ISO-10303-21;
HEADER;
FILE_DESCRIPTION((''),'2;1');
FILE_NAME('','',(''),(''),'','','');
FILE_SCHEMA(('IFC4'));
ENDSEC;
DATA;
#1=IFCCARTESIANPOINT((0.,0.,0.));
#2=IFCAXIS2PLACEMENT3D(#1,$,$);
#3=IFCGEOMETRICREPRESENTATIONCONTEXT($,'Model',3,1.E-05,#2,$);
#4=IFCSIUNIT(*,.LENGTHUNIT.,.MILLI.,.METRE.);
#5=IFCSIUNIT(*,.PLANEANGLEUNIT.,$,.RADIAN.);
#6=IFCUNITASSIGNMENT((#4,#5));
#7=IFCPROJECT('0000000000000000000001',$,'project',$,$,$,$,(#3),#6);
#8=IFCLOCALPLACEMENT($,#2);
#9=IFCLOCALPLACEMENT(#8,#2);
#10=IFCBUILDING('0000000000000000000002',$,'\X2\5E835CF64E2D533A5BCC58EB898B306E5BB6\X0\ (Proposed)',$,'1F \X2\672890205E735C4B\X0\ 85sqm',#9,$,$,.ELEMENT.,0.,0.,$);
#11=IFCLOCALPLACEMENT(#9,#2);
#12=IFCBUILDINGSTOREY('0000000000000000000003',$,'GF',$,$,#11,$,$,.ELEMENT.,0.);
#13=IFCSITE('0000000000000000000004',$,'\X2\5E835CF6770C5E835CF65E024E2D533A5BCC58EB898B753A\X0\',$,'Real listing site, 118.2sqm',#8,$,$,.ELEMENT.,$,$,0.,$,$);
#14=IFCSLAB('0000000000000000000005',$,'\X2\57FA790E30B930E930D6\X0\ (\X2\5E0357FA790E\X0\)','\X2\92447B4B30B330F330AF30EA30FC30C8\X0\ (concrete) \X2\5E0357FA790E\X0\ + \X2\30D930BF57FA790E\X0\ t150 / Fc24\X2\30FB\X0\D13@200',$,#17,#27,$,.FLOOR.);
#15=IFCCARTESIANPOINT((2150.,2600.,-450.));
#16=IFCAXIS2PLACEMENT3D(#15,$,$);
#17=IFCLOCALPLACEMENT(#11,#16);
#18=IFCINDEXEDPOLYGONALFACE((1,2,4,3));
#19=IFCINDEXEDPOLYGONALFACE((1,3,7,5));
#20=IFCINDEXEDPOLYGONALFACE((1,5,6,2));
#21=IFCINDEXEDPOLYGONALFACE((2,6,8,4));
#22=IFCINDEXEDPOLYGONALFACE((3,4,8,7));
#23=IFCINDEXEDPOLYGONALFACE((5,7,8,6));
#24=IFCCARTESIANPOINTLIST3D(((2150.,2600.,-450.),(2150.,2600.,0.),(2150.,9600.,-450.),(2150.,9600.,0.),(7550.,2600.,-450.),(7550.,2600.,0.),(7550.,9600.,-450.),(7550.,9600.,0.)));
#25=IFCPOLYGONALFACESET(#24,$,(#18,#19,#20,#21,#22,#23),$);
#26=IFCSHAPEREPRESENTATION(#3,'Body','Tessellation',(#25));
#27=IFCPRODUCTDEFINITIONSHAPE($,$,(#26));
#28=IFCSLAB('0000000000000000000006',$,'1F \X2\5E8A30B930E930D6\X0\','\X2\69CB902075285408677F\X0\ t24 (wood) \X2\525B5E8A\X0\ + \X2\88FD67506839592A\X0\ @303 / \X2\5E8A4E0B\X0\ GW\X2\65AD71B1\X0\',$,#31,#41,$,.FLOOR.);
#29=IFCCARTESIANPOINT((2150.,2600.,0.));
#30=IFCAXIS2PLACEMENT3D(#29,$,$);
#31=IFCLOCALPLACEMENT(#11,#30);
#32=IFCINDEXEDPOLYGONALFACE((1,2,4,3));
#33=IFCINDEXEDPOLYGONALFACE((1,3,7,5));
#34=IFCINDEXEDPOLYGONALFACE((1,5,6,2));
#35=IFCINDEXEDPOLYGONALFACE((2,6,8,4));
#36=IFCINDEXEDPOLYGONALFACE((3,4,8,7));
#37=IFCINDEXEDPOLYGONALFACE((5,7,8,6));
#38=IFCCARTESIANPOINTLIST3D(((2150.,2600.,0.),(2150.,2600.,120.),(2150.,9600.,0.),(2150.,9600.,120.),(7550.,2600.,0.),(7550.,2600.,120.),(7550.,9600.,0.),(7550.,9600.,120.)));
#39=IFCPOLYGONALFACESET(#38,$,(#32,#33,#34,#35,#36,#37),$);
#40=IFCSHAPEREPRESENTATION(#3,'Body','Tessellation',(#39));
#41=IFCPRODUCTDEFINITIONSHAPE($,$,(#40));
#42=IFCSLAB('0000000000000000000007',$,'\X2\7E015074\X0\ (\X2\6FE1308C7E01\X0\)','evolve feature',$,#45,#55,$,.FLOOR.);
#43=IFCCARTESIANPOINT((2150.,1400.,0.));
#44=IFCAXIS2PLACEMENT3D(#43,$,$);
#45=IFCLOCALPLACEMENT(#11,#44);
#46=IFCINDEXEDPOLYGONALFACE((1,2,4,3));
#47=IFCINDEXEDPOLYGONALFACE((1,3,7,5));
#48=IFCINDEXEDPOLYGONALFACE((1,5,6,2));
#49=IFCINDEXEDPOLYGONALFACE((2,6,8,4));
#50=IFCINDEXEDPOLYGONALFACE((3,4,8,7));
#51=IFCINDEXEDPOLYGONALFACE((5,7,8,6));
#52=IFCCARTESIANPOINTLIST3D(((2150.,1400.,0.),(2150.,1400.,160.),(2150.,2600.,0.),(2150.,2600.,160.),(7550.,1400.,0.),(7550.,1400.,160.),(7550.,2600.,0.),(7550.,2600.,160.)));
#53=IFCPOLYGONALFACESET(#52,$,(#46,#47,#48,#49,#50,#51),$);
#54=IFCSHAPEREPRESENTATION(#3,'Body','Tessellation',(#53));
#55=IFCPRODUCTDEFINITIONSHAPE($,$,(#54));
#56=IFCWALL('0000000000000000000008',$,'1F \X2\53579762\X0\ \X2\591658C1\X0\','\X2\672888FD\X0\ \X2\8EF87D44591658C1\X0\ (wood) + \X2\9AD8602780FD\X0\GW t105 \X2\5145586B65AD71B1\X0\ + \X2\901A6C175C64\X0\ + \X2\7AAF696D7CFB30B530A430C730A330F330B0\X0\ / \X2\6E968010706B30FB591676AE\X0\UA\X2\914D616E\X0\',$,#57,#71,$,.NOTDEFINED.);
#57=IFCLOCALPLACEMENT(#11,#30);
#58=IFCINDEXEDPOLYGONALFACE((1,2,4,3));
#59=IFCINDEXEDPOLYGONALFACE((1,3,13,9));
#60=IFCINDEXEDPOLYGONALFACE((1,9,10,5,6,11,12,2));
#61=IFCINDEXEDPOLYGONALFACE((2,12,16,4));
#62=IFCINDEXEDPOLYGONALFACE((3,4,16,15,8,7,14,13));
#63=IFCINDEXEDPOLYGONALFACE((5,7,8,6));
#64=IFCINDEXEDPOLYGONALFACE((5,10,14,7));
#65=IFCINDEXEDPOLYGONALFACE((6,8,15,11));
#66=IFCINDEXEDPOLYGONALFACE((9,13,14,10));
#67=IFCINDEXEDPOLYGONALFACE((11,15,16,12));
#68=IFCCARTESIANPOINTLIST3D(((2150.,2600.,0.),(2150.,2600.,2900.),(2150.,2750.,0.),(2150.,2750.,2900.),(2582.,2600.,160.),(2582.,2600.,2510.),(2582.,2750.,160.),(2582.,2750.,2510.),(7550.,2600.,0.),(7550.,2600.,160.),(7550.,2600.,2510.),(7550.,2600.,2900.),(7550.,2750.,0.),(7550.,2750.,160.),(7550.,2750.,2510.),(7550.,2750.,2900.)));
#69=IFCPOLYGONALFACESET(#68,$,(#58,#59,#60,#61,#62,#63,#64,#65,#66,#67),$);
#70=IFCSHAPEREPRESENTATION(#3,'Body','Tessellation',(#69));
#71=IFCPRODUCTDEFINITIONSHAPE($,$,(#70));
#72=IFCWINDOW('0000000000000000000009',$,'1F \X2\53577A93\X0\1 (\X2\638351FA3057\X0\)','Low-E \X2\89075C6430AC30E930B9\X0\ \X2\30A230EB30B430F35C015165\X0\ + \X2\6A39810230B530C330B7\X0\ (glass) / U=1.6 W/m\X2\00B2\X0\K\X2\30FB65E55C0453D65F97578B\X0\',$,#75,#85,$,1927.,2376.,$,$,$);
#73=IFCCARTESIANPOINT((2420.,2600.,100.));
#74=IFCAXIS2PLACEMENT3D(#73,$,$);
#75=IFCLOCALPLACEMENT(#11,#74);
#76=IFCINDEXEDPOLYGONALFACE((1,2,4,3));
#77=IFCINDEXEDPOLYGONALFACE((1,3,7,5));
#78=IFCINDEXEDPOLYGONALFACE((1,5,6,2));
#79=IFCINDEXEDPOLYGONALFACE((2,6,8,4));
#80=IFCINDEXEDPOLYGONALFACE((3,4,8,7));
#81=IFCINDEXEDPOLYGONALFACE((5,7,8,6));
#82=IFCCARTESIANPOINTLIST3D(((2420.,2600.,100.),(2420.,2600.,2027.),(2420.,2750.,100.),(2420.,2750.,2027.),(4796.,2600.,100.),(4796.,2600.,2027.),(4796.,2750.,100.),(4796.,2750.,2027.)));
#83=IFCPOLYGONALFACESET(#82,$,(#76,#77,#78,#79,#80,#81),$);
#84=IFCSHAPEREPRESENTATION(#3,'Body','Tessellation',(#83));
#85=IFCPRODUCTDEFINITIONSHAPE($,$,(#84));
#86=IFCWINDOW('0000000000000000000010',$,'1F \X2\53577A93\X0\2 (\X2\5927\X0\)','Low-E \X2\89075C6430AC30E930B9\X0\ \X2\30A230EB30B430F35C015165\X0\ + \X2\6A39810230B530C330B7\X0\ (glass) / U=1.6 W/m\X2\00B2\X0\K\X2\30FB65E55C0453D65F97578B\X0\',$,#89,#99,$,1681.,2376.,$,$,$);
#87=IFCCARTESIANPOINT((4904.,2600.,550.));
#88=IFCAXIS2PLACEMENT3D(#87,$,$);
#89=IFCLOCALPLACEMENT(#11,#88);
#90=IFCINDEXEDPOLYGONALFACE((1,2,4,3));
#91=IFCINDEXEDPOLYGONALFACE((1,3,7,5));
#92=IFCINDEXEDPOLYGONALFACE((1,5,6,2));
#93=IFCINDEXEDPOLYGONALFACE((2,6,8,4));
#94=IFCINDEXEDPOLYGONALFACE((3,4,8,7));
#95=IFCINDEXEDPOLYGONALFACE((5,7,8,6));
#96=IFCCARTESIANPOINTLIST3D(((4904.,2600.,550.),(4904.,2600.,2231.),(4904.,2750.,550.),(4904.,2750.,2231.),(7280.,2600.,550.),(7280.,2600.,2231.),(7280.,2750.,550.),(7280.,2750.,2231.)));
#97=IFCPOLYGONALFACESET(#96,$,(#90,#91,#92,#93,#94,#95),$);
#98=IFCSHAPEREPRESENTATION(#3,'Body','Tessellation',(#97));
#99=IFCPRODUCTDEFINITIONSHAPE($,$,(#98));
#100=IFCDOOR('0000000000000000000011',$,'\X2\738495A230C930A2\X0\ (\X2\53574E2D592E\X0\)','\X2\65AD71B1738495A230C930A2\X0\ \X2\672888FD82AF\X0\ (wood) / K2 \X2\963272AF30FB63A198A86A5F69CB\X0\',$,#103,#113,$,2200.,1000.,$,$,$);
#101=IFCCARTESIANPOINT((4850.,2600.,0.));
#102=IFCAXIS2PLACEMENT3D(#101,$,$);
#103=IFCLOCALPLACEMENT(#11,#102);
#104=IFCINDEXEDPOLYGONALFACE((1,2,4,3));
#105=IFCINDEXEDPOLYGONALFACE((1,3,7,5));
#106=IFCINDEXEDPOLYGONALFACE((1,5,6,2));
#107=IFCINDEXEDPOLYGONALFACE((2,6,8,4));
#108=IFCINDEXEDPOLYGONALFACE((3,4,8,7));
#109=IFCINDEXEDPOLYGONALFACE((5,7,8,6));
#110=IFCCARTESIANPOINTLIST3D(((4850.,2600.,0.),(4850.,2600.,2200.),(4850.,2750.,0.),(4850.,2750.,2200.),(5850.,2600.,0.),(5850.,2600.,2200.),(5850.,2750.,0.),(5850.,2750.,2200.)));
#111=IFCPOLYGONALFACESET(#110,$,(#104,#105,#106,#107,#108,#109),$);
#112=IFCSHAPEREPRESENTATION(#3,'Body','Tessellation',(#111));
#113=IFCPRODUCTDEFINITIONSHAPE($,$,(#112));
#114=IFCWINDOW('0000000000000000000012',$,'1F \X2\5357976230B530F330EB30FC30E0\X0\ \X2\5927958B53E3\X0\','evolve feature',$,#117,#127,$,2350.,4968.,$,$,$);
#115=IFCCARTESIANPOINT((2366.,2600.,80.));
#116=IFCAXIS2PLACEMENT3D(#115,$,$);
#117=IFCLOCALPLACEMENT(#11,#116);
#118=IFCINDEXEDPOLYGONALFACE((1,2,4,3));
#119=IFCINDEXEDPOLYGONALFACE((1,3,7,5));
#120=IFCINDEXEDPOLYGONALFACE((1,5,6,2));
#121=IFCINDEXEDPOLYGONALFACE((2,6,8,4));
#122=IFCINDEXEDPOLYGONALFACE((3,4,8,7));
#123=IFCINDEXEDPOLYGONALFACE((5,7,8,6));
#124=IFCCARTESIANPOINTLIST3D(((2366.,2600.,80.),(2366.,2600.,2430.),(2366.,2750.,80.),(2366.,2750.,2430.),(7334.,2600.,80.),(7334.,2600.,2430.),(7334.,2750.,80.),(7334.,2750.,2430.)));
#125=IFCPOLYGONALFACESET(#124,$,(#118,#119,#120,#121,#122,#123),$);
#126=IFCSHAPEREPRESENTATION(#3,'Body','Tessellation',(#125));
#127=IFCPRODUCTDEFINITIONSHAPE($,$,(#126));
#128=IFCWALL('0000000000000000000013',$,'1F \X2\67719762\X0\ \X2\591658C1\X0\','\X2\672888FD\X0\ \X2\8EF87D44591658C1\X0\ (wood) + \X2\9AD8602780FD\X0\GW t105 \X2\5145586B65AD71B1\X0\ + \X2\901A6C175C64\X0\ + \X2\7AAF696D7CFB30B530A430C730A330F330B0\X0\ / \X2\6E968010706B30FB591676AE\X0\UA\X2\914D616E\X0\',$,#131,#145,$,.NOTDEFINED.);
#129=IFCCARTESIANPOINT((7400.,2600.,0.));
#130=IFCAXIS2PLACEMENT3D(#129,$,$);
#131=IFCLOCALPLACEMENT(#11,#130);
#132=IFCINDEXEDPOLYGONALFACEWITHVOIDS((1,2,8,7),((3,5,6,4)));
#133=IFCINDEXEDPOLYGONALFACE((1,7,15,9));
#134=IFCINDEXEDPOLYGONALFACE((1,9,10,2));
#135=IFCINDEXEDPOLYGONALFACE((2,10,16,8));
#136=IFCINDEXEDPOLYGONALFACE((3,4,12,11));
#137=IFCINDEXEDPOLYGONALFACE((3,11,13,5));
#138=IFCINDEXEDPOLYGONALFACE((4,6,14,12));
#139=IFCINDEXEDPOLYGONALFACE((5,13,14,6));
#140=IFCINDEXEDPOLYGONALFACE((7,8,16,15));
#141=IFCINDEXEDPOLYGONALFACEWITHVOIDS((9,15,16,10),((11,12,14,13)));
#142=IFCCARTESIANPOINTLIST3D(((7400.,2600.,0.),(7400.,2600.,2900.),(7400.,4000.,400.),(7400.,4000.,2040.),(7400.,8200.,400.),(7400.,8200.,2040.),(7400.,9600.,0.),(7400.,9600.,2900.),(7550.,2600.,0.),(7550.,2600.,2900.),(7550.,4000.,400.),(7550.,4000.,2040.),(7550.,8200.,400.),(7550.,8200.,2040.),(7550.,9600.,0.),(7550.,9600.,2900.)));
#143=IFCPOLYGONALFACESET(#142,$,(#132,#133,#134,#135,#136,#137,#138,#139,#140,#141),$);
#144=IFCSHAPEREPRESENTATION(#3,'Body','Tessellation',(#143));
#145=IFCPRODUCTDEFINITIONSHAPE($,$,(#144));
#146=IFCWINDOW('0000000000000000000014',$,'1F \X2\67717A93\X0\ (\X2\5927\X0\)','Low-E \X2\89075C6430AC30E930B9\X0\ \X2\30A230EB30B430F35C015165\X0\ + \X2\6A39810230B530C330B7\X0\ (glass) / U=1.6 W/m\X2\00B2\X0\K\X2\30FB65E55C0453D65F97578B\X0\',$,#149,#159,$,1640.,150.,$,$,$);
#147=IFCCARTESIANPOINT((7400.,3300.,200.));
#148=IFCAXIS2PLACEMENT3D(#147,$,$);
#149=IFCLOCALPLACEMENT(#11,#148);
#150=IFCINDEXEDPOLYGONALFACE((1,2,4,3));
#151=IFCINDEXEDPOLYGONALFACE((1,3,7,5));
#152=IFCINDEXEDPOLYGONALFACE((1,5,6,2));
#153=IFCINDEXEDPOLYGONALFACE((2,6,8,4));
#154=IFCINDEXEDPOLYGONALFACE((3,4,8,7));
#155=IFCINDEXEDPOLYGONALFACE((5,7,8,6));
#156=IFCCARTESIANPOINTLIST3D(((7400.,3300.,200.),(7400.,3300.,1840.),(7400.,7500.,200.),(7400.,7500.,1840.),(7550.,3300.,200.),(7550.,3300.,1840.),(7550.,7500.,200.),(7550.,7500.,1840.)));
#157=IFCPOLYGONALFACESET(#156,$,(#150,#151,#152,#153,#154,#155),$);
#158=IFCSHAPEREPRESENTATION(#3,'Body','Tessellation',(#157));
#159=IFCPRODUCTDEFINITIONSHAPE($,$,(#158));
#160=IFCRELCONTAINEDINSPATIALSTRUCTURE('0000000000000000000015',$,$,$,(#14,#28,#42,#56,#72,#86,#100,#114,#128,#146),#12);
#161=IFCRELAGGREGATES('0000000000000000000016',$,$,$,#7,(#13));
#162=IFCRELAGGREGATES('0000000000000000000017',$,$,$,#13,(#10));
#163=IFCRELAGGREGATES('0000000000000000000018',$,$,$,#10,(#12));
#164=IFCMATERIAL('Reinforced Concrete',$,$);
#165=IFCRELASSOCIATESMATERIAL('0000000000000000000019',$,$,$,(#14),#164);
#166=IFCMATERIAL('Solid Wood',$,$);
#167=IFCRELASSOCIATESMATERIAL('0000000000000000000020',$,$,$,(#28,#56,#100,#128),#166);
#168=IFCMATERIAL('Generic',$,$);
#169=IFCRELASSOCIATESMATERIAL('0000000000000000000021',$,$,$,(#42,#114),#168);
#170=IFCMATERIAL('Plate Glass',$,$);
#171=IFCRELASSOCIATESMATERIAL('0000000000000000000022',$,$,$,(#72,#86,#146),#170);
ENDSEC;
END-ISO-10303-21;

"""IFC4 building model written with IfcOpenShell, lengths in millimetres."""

from ifc_helpers import new_model, si_unit, frame, frame_2d, origin, place, context, project, spatial, rectangle, extrude, material, element, fill, save


model = new_model("IFC4")

# Units and contexts
model_context = context("Model", 3, precision=1e-05, world=origin())
ifc_project = project(units=[si_unit("LENGTHUNIT", "METRE", prefix="MILLI"), si_unit("PLANEANGLEUNIT", "RADIAN")], contexts=[model_context])

# Site, building, storey
site_placement = place(None, origin())
site = spatial("IfcSite", under=ifc_project, at=site_placement, Name="広島県広島市中区富士見町", ObjectType="Real listing site, 118.2sqm", CompositionType="ELEMENT", RefElevation=0.0)
building_placement = place(site_placement, origin())
building = spatial("IfcBuilding", under=site, at=building_placement, Name="広島中区富士見の家 (Proposed)", ObjectType="1F 木造平屋 85sqm", CompositionType="ELEMENT", ElevationOfRefHeight=0.0, ElevationOfTerrain=0.0)
storey_placement = place(building_placement, origin())
storey = spatial("IfcBuildingStorey", under=building, at=storey_placement, Name="GF", CompositionType="ELEMENT", Elevation=0.0)

# Slabs
ifc_material_1 = material(Name="Reinforced Concrete")
slab_1_placement = place(storey_placement, frame((2150.0, 2600.0, -450.0)))
element("IfcSlab", 1, at=slab_1_placement, inside=storey, material=ifc_material_1, Name="基礎スラブ (布基礎)", Description="鉄筋コンクリート (concrete) 布基礎 + ベタ基礎 t150 / Fc24・D13@200", PredefinedType="FLOOR", context=model_context, shape_type="SweptSolid", body=[
    extrude(rectangle(XDim=5400.0, YDim=7000.0, at=frame_2d((2700.0, 3500.0))), frame((2150.0, 2600.0, -450.0)), (0.0, 0.0, 1.0), 450.0),
])
ifc_material_2 = material(Name="Solid Wood")
slab_2_placement = place(storey_placement, frame((2150.0, 2600.0, 0.0)))
element("IfcSlab", 2, at=slab_2_placement, inside=storey, material=ifc_material_2, Name="1F 床スラブ", Description="構造用合板 t24 (wood) 剛床 + 製材根太 @303 / 床下 GW断熱", PredefinedType="FLOOR", context=model_context, shape_type="SweptSolid", body=[
    extrude(rectangle(XDim=5400.0, YDim=7000.0, at=frame_2d((2700.0, 3500.0))), frame((2150.0, 2600.0, 0.0)), (0.0, 0.0, 1.0), 120.0),
])
ifc_material_3 = material(Name="Generic")
slab_3_placement = place(storey_placement, frame((2150.0, 1400.0, 0.0)))
element("IfcSlab", 3, at=slab_3_placement, inside=storey, material=ifc_material_3, Name="縁側 (濡れ縁)", Description="evolve feature", PredefinedType="FLOOR", context=model_context, shape_type="SweptSolid", body=[
    extrude(rectangle(XDim=5400.0, YDim=1200.0, at=frame_2d((2700.0, 600.0))), frame((2150.0, 1400.0, 0.0)), (0.0, 0.0, 1.0), 160.0),
])

# Wall, openings, windows, door
wall_1_placement = place(storey_placement, frame((2150.0, 2600.0, 0.0)))
wall_1 = element("IfcWall", 4, at=wall_1_placement, inside=storey, material=ifc_material_2, Name="1F 南面 外壁", Description="木製 軸組外壁 (wood) + 高性能GW t105 充填断熱 + 通気層 + 窯業系サイディング / 準耐火・外皮UA配慮", PredefinedType="NOTDEFINED", context=model_context, shape_type="SweptSolid", body=[
    extrude(rectangle(XDim=5400.0, YDim=150.0, at=frame_2d((2700.0, 75.0))), frame((2150.0, 2600.0, 0.0)), (0.0, 0.0, 1.0), 2900.0),
])
opening_1_placement = place(storey_placement, frame((2420.0, 2600.0, 100.0)))
opening_1 = element("IfcOpeningElement", 5, at=opening_1_placement, cuts=wall_1, PredefinedType="NOTDEFINED", context=model_context, shape_type="SweptSolid", body=[
    extrude(rectangle(XDim=2376.0, YDim=150.0, at=frame_2d((1188.0, 75.0))), frame((2420.0, 2600.0, 100.0)), (0.0, 0.0, 1.0), 1927.0),
])
opening_2_placement = place(storey_placement, frame((4904.0, 2600.0, 550.0)))
opening_2 = element("IfcOpeningElement", 6, at=opening_2_placement, cuts=wall_1, PredefinedType="NOTDEFINED", context=model_context, shape_type="SweptSolid", body=[
    extrude(rectangle(XDim=2376.0, YDim=150.0, at=frame_2d((1188.0, 75.0))), frame((4904.0, 2600.0, 550.0)), (0.0, 0.0, 1.0), 1681.0),
])
opening_3_placement = place(storey_placement, frame((4850.0, 2600.0, 0.0)))
opening_3 = element("IfcOpeningElement", 7, at=opening_3_placement, cuts=wall_1, PredefinedType="NOTDEFINED", context=model_context, shape_type="SweptSolid", body=[
    extrude(rectangle(XDim=1000.0, YDim=150.0, at=frame_2d((500.0, 75.0))), frame((4850.0, 2600.0, 0.0)), (0.0, 0.0, 1.0), 2200.0),
])
opening_4_placement = place(storey_placement, frame((2366.0, 2600.0, 80.0)))
opening_4 = element("IfcOpeningElement", 8, at=opening_4_placement, cuts=wall_1, PredefinedType="NOTDEFINED", context=model_context, shape_type="SweptSolid", body=[
    extrude(rectangle(XDim=4968.0, YDim=150.0, at=frame_2d((2484.0, 75.0))), frame((2366.0, 2600.0, 80.0)), (0.0, 0.0, 1.0), 2350.0),
])
ifc_material_4 = material(Name="Plate Glass")
window_1_placement = place(storey_placement, frame((2420.0, 2600.0, 100.0)))
window_1 = element("IfcWindow", 9, at=window_1_placement, inside=storey, material=ifc_material_4, Name="1F 南窓1 (掃出し)", Description="Low-E 複層ガラス アルゴン封入 + 樹脂サッシ (glass) / U=1.6 W/m²K・日射取得型", OverallHeight=1927.0, OverallWidth=2376.0, context=model_context, shape_type="SweptSolid", body=[
    extrude(rectangle(XDim=2376.0, YDim=150.0, at=frame_2d((1188.0, 75.0))), frame((2420.0, 2600.0, 100.0)), (0.0, 0.0, 1.0), 1927.0),
])
fill(opening_1, window_1)
window_2_placement = place(storey_placement, frame((4904.0, 2600.0, 550.0)))
window_2 = element("IfcWindow", 10, at=window_2_placement, inside=storey, material=ifc_material_4, Name="1F 南窓2 (大)", Description="Low-E 複層ガラス アルゴン封入 + 樹脂サッシ (glass) / U=1.6 W/m²K・日射取得型", OverallHeight=1681.0, OverallWidth=2376.0, context=model_context, shape_type="SweptSolid", body=[
    extrude(rectangle(XDim=2376.0, YDim=150.0, at=frame_2d((1188.0, 75.0))), frame((4904.0, 2600.0, 550.0)), (0.0, 0.0, 1.0), 1681.0),
])
fill(opening_2, window_2)
door_placement = place(storey_placement, frame((4850.0, 2600.0, 0.0)))
door = element("IfcDoor", 11, at=door_placement, inside=storey, material=ifc_material_2, Name="玄関ドア (南中央)", Description="断熱玄関ドア 木製芯 (wood) / K2 防犯・採風機構", OverallHeight=2200.0, OverallWidth=1000.0, context=model_context, shape_type="SweptSolid", body=[
    extrude(rectangle(XDim=1000.0, YDim=150.0, at=frame_2d((500.0, 75.0))), frame((4850.0, 2600.0, 0.0)), (0.0, 0.0, 1.0), 2200.0),
])
fill(opening_3, door)
window_3_placement = place(storey_placement, frame((2366.0, 2600.0, 80.0)))
window_3 = element("IfcWindow", 12, at=window_3_placement, inside=storey, material=ifc_material_3, Name="1F 南面サンルーム 大開口", Description="evolve feature", OverallHeight=2350.0, OverallWidth=4968.0, context=model_context, shape_type="SweptSolid", body=[
    extrude(rectangle(XDim=4968.0, YDim=150.0, at=frame_2d((2484.0, 75.0))), frame((2366.0, 2600.0, 80.0)), (0.0, 0.0, 1.0), 2350.0),
])
fill(opening_4, window_3)

# Wall, opening, window
wall_2_placement = place(storey_placement, frame((7400.0, 2600.0, 0.0)))
wall_2 = element("IfcWall", 13, at=wall_2_placement, inside=storey, material=ifc_material_2, Name="1F 東面 外壁", Description="木製 軸組外壁 (wood) + 高性能GW t105 充填断熱 + 通気層 + 窯業系サイディング / 準耐火・外皮UA配慮", PredefinedType="NOTDEFINED", context=model_context, shape_type="SweptSolid", body=[
    extrude(rectangle(XDim=150.0, YDim=7000.0, at=frame_2d((75.0, 3500.0))), frame((7400.0, 2600.0, 0.0)), (0.0, 0.0, 1.0), 2900.0),
])
opening_5_placement = place(storey_placement, frame((7400.0, 3300.0, 200.0)))
opening_5 = element("IfcOpeningElement", 14, at=opening_5_placement, cuts=wall_2, PredefinedType="NOTDEFINED", context=model_context, shape_type="SweptSolid", body=[
    extrude(rectangle(XDim=150.0, YDim=4200.0, at=frame_2d((75.0, 2100.0))), frame((7400.0, 3300.0, 200.0)), (0.0, 0.0, 1.0), 1640.0),
])
window_4_placement = place(storey_placement, frame((7400.0, 3300.0, 200.0)))
window_4 = element("IfcWindow", 15, at=window_4_placement, inside=storey, material=ifc_material_4, Name="1F 東窓 (大)", Description="Low-E 複層ガラス アルゴン封入 + 樹脂サッシ (glass) / U=1.6 W/m²K・日射取得型", OverallHeight=1640.0, OverallWidth=150.0, context=model_context, shape_type="SweptSolid", body=[
    extrude(rectangle(XDim=150.0, YDim=4200.0, at=frame_2d((75.0, 2100.0))), frame((7400.0, 3300.0, 200.0)), (0.0, 0.0, 1.0), 1640.0),
])
fill(opening_5, window_4)

save(model, "model.ifc")
